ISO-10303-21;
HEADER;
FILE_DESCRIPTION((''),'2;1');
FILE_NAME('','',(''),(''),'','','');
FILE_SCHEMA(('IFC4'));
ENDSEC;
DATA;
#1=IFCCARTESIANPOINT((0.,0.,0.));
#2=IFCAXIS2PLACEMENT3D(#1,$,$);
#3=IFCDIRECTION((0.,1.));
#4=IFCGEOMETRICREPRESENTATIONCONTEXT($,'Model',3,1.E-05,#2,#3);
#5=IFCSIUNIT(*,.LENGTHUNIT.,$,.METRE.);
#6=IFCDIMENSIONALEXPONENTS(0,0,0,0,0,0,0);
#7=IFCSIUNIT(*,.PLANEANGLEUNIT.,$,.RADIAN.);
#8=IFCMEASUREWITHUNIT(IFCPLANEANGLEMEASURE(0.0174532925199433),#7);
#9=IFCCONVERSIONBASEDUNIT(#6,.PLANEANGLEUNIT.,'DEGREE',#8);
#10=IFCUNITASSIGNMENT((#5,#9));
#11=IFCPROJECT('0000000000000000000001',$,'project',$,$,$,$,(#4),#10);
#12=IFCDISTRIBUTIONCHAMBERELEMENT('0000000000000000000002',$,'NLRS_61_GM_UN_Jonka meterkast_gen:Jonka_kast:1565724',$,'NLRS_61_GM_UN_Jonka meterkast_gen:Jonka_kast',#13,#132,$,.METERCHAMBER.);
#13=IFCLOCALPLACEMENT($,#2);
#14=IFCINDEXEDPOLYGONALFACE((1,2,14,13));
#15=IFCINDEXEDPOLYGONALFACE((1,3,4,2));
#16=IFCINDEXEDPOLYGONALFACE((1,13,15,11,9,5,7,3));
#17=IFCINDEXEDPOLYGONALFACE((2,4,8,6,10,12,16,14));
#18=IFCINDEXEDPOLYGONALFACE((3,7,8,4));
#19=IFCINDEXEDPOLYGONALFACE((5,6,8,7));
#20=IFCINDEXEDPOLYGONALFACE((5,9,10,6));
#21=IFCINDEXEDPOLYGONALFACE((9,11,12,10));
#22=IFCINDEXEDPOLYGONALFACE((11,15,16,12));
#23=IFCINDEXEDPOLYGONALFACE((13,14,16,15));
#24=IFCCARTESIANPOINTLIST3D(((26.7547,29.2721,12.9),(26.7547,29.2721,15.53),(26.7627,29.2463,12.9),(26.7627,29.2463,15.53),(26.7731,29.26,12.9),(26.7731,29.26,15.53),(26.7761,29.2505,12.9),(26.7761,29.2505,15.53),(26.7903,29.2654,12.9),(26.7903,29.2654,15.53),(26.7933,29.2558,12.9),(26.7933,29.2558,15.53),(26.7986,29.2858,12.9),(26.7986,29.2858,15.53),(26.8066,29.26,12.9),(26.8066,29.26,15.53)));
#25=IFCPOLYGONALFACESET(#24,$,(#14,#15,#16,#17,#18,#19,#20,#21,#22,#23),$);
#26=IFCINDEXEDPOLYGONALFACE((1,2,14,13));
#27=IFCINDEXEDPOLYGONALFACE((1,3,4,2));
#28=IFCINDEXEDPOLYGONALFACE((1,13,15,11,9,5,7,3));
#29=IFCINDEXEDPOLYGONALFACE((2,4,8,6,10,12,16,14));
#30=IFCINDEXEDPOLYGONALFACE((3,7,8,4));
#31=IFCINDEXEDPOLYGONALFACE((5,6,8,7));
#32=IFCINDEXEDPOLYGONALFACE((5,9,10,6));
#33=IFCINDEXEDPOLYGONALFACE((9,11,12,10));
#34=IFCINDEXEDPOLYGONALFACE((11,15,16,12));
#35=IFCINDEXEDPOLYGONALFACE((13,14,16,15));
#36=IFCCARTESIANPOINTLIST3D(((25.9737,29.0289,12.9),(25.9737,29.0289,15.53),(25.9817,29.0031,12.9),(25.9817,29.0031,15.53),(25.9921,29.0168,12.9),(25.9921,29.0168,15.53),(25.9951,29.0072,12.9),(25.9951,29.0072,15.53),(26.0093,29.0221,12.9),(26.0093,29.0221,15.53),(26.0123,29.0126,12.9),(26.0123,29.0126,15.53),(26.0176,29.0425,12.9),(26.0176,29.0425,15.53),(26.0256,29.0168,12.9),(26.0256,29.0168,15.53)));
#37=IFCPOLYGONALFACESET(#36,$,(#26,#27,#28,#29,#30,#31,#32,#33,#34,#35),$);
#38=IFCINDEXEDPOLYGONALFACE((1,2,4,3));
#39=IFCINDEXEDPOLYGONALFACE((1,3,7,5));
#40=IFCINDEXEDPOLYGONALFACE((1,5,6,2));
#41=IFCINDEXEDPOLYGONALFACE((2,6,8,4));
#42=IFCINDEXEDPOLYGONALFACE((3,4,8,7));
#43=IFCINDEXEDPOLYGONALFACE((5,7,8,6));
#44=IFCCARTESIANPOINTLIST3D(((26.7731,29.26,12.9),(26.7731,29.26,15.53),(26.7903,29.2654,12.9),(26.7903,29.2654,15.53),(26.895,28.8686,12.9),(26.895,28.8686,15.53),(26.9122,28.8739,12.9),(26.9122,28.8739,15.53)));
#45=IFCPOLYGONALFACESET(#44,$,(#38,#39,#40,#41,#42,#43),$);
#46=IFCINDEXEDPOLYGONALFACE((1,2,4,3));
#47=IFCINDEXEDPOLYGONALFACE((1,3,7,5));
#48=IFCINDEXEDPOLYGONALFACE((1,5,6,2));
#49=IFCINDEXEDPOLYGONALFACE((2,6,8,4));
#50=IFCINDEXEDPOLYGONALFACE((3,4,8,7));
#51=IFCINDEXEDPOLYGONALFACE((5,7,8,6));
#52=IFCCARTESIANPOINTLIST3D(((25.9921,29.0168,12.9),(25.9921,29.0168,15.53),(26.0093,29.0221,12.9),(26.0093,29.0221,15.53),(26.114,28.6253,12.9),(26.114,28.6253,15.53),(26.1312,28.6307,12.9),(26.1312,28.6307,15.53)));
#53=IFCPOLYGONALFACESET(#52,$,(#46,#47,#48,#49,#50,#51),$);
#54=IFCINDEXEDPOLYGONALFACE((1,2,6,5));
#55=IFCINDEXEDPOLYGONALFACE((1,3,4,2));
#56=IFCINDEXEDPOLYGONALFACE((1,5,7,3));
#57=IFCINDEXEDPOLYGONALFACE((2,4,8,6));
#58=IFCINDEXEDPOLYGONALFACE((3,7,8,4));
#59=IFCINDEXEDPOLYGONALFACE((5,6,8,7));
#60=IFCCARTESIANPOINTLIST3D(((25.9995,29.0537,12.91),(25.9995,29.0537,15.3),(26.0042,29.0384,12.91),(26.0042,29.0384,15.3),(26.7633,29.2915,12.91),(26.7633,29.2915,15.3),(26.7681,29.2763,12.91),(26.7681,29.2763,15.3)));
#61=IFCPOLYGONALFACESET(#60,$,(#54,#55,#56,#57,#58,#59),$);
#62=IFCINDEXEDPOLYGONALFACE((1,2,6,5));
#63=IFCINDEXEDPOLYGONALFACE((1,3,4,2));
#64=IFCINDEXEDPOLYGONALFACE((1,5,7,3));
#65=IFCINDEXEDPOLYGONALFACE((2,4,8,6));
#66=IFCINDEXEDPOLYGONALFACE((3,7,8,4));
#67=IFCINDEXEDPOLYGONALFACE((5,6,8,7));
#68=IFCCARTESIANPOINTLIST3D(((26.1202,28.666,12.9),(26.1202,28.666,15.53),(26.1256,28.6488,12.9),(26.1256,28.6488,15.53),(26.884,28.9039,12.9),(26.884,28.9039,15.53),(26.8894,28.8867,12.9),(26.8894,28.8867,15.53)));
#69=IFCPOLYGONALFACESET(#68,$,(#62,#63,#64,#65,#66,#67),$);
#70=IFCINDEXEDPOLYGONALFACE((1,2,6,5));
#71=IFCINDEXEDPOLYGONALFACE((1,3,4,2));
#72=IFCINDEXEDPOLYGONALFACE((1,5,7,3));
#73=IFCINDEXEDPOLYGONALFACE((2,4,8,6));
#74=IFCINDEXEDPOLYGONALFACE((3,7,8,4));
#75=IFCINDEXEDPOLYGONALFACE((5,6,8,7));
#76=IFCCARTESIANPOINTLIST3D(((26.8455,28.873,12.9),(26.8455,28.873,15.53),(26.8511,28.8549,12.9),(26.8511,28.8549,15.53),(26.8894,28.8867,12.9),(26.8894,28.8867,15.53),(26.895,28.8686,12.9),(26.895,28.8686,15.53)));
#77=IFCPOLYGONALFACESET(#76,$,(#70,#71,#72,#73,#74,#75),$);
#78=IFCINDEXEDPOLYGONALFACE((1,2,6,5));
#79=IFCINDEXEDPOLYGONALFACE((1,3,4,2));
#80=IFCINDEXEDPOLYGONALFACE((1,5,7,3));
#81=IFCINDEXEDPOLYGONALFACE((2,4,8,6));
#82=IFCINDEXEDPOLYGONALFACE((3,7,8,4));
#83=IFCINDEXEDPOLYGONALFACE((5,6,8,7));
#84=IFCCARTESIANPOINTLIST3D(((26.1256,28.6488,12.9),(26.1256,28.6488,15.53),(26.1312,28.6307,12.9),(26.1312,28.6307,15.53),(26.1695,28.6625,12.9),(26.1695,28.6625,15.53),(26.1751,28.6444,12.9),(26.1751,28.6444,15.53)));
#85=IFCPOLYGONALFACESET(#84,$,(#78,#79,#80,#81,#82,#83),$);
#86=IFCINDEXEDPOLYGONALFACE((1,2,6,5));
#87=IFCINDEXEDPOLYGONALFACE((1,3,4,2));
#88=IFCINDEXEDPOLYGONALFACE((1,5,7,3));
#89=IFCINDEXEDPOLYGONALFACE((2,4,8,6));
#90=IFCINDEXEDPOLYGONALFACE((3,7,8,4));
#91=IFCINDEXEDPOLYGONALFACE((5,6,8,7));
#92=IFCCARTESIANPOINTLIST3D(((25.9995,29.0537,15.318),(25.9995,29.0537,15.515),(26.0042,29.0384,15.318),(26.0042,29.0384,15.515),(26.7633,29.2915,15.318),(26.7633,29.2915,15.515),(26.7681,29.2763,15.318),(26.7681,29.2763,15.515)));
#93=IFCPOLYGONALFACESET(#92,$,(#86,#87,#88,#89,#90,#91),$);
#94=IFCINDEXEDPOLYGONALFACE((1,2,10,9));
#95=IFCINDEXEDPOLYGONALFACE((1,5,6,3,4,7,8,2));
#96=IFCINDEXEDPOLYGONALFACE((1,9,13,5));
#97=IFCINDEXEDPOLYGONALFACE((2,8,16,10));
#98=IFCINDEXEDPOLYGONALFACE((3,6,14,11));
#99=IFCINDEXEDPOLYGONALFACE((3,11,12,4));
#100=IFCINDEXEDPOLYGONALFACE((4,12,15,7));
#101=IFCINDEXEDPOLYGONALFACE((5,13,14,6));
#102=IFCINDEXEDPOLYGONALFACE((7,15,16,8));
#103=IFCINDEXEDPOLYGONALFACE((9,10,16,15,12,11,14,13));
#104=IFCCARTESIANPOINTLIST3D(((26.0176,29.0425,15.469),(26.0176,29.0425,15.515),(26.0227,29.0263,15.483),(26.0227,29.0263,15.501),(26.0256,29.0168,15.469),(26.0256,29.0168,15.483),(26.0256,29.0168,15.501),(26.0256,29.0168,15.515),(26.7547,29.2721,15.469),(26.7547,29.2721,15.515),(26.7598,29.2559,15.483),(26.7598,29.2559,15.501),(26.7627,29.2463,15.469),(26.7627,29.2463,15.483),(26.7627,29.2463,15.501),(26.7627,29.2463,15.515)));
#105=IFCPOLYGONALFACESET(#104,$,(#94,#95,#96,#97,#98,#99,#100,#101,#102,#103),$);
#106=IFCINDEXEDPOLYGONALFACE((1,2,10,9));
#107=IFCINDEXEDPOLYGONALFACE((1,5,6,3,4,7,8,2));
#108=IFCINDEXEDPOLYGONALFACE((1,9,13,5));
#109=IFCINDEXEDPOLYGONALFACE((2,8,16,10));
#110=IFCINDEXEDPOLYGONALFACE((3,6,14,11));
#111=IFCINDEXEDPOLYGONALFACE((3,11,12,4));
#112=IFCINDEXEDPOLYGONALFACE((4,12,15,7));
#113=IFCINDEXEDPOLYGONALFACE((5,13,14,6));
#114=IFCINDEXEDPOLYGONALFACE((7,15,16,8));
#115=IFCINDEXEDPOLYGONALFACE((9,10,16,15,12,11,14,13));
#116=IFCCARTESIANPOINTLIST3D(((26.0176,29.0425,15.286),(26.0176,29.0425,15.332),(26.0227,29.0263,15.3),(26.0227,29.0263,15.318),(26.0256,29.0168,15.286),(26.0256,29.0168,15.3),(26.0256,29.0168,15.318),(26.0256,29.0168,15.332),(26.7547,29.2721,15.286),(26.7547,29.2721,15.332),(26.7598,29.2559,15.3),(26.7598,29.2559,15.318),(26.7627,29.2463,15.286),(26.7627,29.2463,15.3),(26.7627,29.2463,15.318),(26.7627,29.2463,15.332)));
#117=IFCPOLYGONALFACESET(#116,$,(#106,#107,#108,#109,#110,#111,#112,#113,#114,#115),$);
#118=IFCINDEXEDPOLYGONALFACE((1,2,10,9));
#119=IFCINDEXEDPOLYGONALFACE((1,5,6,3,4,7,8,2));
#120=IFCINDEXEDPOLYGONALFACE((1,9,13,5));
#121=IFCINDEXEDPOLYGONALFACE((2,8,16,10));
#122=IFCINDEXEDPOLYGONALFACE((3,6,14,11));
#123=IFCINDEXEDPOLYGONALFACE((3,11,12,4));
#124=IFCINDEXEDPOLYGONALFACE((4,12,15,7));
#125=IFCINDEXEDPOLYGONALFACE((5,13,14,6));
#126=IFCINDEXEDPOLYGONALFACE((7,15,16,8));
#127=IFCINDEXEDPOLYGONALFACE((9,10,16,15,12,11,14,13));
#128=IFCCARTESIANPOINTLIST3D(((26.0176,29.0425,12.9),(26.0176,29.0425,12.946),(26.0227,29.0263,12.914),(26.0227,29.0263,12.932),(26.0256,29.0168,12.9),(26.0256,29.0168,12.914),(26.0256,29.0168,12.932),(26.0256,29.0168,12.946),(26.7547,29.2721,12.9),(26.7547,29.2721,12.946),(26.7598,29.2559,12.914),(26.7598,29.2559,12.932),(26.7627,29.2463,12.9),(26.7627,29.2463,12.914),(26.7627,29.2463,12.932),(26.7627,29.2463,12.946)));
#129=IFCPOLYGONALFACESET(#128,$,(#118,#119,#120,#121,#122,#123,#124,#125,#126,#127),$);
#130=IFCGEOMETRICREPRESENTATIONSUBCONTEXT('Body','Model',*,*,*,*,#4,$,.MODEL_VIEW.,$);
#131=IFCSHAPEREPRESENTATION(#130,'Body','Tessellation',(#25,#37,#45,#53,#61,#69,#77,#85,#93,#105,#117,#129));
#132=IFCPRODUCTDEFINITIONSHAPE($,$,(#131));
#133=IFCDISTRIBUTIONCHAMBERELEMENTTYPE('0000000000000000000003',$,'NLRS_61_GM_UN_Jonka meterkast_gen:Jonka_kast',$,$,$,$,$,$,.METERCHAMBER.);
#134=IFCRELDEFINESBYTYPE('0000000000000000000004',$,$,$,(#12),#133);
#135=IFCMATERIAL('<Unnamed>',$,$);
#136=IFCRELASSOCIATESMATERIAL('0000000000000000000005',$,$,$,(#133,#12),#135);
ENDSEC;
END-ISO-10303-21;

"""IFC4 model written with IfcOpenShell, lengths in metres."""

from ifc_helpers import new_model, entity, si_unit, converted_unit, direction, frame, origin, place, context, subcontext, project, indexed_curve, outline, extrude, source, transform, mapped, material, type_object, type_shapes, element, save


model = new_model("IFC4")

# Units and contexts
model_context = context("Model", 3, precision=1e-05, world=origin(), true_north=direction((0.0, 1.0)))
body_context = subcontext(model_context, "Body", "Model", "MODEL_VIEW")
ifc_project = project(units=[si_unit("LENGTHUNIT", "METRE"), converted_unit("PLANEANGLEUNIT", "DEGREE", entity("IfcPlaneAngleMeasure", 0.0174532925199433), si_unit("PLANEANGLEUNIT", "RADIAN"), dimensions=[0, 0, 0, 0, 0, 0, 0])], contexts=[model_context])

# Distribution chamber element
ifc_material = material(Name="<Unnamed>")
distribution_chamber_element_type = type_object("IfcDistributionChamberElementType", Name="NLRS_61_GM_UN_Jonka meterkast_gen:Jonka_kast", PredefinedType="METERCHAMBER", material=ifc_material)
shared_shape_1 = source(origin(), body_context, "Body", "SweptSolid", [
    extrude(outline(indexed_curve([(-0.0093, -0.023), (0.0178, -0.023), (0.0178, 0.023), (-0.0093, 0.023), (-0.0093, 0.009), (0.0007, 0.009), (0.0007, -0.009), (-0.0093, -0.009), (-0.0093, -0.023)], self_intersect=False)), frame((-0.409, -0.4092, 0.0), z_axis=(0.0, 0.0, 1.0), x_axis=(0.0, -1.0, 0.0)), (0.0, 0.0, 1.0), 2.63),
    extrude(outline(indexed_curve([(-0.0093, -0.023), (0.0178, -0.023), (0.0178, 0.023), (-0.0093, 0.023), (-0.0093, 0.009), (0.0007, 0.009), (0.0007, -0.009), (-0.0093, -0.009), (-0.0093, -0.023)], self_intersect=False)), frame((0.409, -0.4092, 0.0), z_axis=(0.0, 0.0, 1.0), x_axis=(0.0, -1.0, 0.0)), (0.0, 0.0, 1.0), 2.63),
    extrude(outline(indexed_curve([(-0.205, -0.009), (0.205, -0.009), (0.205, 0.009), (-0.205, 0.009), (-0.205, -0.009)], self_intersect=False)), frame((-0.409, -0.205, 0.0), z_axis=(0.0, 0.0, 1.0), x_axis=(0.0, -1.0, 0.0)), (0.0, 0.0, 1.0), 2.63),
    extrude(outline(indexed_curve([(-0.205, -0.009), (0.205, -0.009), (0.205, 0.009), (-0.205, 0.009), (-0.205, -0.009)], self_intersect=False)), frame((0.409, -0.205, 0.0), z_axis=(0.0, 0.0, 1.0), x_axis=(0.0, -1.0, 0.0)), (0.0, 0.0, 1.0), 2.63),
    extrude(outline(indexed_curve([(-0.4, -0.008), (0.4, -0.008), (0.4, 0.008), (-0.4, 0.008), (-0.4, -0.008)], self_intersect=False)), frame((0.0, -0.435, 0.01), z_axis=(0.0, 0.0, 1.0), x_axis=(-1.0, 0.0, 0.0)), (0.0, 0.0, 1.0), 2.39),
    extrude(outline(indexed_curve([(-0.4, -0.009), (0.4, -0.009), (0.4, 0.009), (-0.4, 0.009), (-0.4, -0.009)], self_intersect=False)), frame((0.0, -0.028, 0.0), z_axis=(0.0, 0.0, 1.0), x_axis=(-1.0, 0.0, 0.0)), (0.0, 0.0, 1.0), 2.63),
    extrude(outline(indexed_curve([(-0.023, -0.0095), (0.023, -0.0095), (0.023, 0.0095), (-0.023, 0.0095), (-0.023, -0.0095)], self_intersect=False)), frame((-0.377, -0.0095, 0.0), z_axis=(0.0, 0.0, 1.0), x_axis=(-1.0, 0.0, 0.0)), (0.0, 0.0, 1.0), 2.63),
    extrude(outline(indexed_curve([(-0.023, -0.0095), (0.023, -0.0095), (0.023, 0.0095), (-0.023, 0.0095), (-0.023, -0.0095)], self_intersect=False)), frame((0.377, -0.0095, 0.0), z_axis=(0.0, 0.0, 1.0), x_axis=(-1.0, 0.0, 0.0)), (0.0, 0.0, 1.0), 2.63),
    extrude(outline(indexed_curve([(-0.4, -0.008), (0.4, -0.008), (0.4, 0.008), (-0.4, 0.008), (-0.4, -0.008)], self_intersect=False)), frame((0.0, -0.435, 2.418), z_axis=(0.0, 0.0, 1.0), x_axis=(-1.0, 0.0, 0.0)), (0.0, 0.0, 1.0), 0.197),
    extrude(outline(indexed_curve([(-0.023, -0.0178), (0.023, -0.0178), (0.023, 0.0093), (0.009, 0.0093), (0.009, -0.0007), (-0.009, -0.0007), (-0.009, 0.0093), (-0.023, 0.0093), (-0.023, -0.0178)], self_intersect=False)), frame((-0.386, -0.4092, 2.592), z_axis=(1.0, 0.0, 0.0), x_axis=(0.0, 0.0, -1.0)), (0.0, 0.0, 1.0), 0.772),
    extrude(outline(indexed_curve([(-0.023, -0.0178), (0.023, -0.0178), (0.023, 0.0093), (0.009, 0.0093), (0.009, -0.0007), (-0.009, -0.0007), (-0.009, 0.0093), (-0.023, 0.0093), (-0.023, -0.0178)], self_intersect=False)), frame((-0.386, -0.4092, 2.409), z_axis=(1.0, 0.0, 0.0), x_axis=(0.0, 0.0, -1.0)), (0.0, 0.0, 1.0), 0.772),
    extrude(outline(indexed_curve([(-0.023, -0.0178), (0.023, -0.0178), (0.023, 0.0093), (0.009, 0.0093), (0.009, -0.0007), (-0.009, -0.0007), (-0.009, 0.0093), (-0.023, 0.0093), (-0.023, -0.0178)], self_intersect=False)), frame((-0.386, -0.4092, 0.023), z_axis=(1.0, 0.0, 0.0), x_axis=(0.0, 0.0, -1.0)), (0.0, 0.0, 1.0), 0.772),
])
type_shapes(distribution_chamber_element_type, [shared_shape_1])
placement_1 = place(None, frame((13.1348, 11.9886, 0.0), z_axis=(0.0, 0.0, 1.0), x_axis=(0.954771, 0.297342, 0.0)))
placement_2 = place(placement_1, origin())
placement_3 = place(placement_2, frame((0.0, 0.0, 12.9)))
placement_4 = place(placement_3, origin())
distribution_chamber_element_1_placement = place(placement_4, frame((17.757, 12.025, 0.0), z_axis=(0.0, 0.0, 1.0), x_axis=(-1.0, 0.0, 0.0)))
element("IfcDistributionChamberElement", 1, at=distribution_chamber_element_1_placement, type_object=distribution_chamber_element_type, material=ifc_material, Name="NLRS_61_GM_UN_Jonka meterkast_gen:Jonka_kast:1565724", ObjectType="NLRS_61_GM_UN_Jonka meterkast_gen:Jonka_kast", PredefinedType="METERCHAMBER", context=body_context, shape_type="MappedRepresentation", body=[
    mapped(shared_shape_1, transform((0.0, 0.0, 0.0), scale=1.0)),
])

save(model, "model.ifc")
